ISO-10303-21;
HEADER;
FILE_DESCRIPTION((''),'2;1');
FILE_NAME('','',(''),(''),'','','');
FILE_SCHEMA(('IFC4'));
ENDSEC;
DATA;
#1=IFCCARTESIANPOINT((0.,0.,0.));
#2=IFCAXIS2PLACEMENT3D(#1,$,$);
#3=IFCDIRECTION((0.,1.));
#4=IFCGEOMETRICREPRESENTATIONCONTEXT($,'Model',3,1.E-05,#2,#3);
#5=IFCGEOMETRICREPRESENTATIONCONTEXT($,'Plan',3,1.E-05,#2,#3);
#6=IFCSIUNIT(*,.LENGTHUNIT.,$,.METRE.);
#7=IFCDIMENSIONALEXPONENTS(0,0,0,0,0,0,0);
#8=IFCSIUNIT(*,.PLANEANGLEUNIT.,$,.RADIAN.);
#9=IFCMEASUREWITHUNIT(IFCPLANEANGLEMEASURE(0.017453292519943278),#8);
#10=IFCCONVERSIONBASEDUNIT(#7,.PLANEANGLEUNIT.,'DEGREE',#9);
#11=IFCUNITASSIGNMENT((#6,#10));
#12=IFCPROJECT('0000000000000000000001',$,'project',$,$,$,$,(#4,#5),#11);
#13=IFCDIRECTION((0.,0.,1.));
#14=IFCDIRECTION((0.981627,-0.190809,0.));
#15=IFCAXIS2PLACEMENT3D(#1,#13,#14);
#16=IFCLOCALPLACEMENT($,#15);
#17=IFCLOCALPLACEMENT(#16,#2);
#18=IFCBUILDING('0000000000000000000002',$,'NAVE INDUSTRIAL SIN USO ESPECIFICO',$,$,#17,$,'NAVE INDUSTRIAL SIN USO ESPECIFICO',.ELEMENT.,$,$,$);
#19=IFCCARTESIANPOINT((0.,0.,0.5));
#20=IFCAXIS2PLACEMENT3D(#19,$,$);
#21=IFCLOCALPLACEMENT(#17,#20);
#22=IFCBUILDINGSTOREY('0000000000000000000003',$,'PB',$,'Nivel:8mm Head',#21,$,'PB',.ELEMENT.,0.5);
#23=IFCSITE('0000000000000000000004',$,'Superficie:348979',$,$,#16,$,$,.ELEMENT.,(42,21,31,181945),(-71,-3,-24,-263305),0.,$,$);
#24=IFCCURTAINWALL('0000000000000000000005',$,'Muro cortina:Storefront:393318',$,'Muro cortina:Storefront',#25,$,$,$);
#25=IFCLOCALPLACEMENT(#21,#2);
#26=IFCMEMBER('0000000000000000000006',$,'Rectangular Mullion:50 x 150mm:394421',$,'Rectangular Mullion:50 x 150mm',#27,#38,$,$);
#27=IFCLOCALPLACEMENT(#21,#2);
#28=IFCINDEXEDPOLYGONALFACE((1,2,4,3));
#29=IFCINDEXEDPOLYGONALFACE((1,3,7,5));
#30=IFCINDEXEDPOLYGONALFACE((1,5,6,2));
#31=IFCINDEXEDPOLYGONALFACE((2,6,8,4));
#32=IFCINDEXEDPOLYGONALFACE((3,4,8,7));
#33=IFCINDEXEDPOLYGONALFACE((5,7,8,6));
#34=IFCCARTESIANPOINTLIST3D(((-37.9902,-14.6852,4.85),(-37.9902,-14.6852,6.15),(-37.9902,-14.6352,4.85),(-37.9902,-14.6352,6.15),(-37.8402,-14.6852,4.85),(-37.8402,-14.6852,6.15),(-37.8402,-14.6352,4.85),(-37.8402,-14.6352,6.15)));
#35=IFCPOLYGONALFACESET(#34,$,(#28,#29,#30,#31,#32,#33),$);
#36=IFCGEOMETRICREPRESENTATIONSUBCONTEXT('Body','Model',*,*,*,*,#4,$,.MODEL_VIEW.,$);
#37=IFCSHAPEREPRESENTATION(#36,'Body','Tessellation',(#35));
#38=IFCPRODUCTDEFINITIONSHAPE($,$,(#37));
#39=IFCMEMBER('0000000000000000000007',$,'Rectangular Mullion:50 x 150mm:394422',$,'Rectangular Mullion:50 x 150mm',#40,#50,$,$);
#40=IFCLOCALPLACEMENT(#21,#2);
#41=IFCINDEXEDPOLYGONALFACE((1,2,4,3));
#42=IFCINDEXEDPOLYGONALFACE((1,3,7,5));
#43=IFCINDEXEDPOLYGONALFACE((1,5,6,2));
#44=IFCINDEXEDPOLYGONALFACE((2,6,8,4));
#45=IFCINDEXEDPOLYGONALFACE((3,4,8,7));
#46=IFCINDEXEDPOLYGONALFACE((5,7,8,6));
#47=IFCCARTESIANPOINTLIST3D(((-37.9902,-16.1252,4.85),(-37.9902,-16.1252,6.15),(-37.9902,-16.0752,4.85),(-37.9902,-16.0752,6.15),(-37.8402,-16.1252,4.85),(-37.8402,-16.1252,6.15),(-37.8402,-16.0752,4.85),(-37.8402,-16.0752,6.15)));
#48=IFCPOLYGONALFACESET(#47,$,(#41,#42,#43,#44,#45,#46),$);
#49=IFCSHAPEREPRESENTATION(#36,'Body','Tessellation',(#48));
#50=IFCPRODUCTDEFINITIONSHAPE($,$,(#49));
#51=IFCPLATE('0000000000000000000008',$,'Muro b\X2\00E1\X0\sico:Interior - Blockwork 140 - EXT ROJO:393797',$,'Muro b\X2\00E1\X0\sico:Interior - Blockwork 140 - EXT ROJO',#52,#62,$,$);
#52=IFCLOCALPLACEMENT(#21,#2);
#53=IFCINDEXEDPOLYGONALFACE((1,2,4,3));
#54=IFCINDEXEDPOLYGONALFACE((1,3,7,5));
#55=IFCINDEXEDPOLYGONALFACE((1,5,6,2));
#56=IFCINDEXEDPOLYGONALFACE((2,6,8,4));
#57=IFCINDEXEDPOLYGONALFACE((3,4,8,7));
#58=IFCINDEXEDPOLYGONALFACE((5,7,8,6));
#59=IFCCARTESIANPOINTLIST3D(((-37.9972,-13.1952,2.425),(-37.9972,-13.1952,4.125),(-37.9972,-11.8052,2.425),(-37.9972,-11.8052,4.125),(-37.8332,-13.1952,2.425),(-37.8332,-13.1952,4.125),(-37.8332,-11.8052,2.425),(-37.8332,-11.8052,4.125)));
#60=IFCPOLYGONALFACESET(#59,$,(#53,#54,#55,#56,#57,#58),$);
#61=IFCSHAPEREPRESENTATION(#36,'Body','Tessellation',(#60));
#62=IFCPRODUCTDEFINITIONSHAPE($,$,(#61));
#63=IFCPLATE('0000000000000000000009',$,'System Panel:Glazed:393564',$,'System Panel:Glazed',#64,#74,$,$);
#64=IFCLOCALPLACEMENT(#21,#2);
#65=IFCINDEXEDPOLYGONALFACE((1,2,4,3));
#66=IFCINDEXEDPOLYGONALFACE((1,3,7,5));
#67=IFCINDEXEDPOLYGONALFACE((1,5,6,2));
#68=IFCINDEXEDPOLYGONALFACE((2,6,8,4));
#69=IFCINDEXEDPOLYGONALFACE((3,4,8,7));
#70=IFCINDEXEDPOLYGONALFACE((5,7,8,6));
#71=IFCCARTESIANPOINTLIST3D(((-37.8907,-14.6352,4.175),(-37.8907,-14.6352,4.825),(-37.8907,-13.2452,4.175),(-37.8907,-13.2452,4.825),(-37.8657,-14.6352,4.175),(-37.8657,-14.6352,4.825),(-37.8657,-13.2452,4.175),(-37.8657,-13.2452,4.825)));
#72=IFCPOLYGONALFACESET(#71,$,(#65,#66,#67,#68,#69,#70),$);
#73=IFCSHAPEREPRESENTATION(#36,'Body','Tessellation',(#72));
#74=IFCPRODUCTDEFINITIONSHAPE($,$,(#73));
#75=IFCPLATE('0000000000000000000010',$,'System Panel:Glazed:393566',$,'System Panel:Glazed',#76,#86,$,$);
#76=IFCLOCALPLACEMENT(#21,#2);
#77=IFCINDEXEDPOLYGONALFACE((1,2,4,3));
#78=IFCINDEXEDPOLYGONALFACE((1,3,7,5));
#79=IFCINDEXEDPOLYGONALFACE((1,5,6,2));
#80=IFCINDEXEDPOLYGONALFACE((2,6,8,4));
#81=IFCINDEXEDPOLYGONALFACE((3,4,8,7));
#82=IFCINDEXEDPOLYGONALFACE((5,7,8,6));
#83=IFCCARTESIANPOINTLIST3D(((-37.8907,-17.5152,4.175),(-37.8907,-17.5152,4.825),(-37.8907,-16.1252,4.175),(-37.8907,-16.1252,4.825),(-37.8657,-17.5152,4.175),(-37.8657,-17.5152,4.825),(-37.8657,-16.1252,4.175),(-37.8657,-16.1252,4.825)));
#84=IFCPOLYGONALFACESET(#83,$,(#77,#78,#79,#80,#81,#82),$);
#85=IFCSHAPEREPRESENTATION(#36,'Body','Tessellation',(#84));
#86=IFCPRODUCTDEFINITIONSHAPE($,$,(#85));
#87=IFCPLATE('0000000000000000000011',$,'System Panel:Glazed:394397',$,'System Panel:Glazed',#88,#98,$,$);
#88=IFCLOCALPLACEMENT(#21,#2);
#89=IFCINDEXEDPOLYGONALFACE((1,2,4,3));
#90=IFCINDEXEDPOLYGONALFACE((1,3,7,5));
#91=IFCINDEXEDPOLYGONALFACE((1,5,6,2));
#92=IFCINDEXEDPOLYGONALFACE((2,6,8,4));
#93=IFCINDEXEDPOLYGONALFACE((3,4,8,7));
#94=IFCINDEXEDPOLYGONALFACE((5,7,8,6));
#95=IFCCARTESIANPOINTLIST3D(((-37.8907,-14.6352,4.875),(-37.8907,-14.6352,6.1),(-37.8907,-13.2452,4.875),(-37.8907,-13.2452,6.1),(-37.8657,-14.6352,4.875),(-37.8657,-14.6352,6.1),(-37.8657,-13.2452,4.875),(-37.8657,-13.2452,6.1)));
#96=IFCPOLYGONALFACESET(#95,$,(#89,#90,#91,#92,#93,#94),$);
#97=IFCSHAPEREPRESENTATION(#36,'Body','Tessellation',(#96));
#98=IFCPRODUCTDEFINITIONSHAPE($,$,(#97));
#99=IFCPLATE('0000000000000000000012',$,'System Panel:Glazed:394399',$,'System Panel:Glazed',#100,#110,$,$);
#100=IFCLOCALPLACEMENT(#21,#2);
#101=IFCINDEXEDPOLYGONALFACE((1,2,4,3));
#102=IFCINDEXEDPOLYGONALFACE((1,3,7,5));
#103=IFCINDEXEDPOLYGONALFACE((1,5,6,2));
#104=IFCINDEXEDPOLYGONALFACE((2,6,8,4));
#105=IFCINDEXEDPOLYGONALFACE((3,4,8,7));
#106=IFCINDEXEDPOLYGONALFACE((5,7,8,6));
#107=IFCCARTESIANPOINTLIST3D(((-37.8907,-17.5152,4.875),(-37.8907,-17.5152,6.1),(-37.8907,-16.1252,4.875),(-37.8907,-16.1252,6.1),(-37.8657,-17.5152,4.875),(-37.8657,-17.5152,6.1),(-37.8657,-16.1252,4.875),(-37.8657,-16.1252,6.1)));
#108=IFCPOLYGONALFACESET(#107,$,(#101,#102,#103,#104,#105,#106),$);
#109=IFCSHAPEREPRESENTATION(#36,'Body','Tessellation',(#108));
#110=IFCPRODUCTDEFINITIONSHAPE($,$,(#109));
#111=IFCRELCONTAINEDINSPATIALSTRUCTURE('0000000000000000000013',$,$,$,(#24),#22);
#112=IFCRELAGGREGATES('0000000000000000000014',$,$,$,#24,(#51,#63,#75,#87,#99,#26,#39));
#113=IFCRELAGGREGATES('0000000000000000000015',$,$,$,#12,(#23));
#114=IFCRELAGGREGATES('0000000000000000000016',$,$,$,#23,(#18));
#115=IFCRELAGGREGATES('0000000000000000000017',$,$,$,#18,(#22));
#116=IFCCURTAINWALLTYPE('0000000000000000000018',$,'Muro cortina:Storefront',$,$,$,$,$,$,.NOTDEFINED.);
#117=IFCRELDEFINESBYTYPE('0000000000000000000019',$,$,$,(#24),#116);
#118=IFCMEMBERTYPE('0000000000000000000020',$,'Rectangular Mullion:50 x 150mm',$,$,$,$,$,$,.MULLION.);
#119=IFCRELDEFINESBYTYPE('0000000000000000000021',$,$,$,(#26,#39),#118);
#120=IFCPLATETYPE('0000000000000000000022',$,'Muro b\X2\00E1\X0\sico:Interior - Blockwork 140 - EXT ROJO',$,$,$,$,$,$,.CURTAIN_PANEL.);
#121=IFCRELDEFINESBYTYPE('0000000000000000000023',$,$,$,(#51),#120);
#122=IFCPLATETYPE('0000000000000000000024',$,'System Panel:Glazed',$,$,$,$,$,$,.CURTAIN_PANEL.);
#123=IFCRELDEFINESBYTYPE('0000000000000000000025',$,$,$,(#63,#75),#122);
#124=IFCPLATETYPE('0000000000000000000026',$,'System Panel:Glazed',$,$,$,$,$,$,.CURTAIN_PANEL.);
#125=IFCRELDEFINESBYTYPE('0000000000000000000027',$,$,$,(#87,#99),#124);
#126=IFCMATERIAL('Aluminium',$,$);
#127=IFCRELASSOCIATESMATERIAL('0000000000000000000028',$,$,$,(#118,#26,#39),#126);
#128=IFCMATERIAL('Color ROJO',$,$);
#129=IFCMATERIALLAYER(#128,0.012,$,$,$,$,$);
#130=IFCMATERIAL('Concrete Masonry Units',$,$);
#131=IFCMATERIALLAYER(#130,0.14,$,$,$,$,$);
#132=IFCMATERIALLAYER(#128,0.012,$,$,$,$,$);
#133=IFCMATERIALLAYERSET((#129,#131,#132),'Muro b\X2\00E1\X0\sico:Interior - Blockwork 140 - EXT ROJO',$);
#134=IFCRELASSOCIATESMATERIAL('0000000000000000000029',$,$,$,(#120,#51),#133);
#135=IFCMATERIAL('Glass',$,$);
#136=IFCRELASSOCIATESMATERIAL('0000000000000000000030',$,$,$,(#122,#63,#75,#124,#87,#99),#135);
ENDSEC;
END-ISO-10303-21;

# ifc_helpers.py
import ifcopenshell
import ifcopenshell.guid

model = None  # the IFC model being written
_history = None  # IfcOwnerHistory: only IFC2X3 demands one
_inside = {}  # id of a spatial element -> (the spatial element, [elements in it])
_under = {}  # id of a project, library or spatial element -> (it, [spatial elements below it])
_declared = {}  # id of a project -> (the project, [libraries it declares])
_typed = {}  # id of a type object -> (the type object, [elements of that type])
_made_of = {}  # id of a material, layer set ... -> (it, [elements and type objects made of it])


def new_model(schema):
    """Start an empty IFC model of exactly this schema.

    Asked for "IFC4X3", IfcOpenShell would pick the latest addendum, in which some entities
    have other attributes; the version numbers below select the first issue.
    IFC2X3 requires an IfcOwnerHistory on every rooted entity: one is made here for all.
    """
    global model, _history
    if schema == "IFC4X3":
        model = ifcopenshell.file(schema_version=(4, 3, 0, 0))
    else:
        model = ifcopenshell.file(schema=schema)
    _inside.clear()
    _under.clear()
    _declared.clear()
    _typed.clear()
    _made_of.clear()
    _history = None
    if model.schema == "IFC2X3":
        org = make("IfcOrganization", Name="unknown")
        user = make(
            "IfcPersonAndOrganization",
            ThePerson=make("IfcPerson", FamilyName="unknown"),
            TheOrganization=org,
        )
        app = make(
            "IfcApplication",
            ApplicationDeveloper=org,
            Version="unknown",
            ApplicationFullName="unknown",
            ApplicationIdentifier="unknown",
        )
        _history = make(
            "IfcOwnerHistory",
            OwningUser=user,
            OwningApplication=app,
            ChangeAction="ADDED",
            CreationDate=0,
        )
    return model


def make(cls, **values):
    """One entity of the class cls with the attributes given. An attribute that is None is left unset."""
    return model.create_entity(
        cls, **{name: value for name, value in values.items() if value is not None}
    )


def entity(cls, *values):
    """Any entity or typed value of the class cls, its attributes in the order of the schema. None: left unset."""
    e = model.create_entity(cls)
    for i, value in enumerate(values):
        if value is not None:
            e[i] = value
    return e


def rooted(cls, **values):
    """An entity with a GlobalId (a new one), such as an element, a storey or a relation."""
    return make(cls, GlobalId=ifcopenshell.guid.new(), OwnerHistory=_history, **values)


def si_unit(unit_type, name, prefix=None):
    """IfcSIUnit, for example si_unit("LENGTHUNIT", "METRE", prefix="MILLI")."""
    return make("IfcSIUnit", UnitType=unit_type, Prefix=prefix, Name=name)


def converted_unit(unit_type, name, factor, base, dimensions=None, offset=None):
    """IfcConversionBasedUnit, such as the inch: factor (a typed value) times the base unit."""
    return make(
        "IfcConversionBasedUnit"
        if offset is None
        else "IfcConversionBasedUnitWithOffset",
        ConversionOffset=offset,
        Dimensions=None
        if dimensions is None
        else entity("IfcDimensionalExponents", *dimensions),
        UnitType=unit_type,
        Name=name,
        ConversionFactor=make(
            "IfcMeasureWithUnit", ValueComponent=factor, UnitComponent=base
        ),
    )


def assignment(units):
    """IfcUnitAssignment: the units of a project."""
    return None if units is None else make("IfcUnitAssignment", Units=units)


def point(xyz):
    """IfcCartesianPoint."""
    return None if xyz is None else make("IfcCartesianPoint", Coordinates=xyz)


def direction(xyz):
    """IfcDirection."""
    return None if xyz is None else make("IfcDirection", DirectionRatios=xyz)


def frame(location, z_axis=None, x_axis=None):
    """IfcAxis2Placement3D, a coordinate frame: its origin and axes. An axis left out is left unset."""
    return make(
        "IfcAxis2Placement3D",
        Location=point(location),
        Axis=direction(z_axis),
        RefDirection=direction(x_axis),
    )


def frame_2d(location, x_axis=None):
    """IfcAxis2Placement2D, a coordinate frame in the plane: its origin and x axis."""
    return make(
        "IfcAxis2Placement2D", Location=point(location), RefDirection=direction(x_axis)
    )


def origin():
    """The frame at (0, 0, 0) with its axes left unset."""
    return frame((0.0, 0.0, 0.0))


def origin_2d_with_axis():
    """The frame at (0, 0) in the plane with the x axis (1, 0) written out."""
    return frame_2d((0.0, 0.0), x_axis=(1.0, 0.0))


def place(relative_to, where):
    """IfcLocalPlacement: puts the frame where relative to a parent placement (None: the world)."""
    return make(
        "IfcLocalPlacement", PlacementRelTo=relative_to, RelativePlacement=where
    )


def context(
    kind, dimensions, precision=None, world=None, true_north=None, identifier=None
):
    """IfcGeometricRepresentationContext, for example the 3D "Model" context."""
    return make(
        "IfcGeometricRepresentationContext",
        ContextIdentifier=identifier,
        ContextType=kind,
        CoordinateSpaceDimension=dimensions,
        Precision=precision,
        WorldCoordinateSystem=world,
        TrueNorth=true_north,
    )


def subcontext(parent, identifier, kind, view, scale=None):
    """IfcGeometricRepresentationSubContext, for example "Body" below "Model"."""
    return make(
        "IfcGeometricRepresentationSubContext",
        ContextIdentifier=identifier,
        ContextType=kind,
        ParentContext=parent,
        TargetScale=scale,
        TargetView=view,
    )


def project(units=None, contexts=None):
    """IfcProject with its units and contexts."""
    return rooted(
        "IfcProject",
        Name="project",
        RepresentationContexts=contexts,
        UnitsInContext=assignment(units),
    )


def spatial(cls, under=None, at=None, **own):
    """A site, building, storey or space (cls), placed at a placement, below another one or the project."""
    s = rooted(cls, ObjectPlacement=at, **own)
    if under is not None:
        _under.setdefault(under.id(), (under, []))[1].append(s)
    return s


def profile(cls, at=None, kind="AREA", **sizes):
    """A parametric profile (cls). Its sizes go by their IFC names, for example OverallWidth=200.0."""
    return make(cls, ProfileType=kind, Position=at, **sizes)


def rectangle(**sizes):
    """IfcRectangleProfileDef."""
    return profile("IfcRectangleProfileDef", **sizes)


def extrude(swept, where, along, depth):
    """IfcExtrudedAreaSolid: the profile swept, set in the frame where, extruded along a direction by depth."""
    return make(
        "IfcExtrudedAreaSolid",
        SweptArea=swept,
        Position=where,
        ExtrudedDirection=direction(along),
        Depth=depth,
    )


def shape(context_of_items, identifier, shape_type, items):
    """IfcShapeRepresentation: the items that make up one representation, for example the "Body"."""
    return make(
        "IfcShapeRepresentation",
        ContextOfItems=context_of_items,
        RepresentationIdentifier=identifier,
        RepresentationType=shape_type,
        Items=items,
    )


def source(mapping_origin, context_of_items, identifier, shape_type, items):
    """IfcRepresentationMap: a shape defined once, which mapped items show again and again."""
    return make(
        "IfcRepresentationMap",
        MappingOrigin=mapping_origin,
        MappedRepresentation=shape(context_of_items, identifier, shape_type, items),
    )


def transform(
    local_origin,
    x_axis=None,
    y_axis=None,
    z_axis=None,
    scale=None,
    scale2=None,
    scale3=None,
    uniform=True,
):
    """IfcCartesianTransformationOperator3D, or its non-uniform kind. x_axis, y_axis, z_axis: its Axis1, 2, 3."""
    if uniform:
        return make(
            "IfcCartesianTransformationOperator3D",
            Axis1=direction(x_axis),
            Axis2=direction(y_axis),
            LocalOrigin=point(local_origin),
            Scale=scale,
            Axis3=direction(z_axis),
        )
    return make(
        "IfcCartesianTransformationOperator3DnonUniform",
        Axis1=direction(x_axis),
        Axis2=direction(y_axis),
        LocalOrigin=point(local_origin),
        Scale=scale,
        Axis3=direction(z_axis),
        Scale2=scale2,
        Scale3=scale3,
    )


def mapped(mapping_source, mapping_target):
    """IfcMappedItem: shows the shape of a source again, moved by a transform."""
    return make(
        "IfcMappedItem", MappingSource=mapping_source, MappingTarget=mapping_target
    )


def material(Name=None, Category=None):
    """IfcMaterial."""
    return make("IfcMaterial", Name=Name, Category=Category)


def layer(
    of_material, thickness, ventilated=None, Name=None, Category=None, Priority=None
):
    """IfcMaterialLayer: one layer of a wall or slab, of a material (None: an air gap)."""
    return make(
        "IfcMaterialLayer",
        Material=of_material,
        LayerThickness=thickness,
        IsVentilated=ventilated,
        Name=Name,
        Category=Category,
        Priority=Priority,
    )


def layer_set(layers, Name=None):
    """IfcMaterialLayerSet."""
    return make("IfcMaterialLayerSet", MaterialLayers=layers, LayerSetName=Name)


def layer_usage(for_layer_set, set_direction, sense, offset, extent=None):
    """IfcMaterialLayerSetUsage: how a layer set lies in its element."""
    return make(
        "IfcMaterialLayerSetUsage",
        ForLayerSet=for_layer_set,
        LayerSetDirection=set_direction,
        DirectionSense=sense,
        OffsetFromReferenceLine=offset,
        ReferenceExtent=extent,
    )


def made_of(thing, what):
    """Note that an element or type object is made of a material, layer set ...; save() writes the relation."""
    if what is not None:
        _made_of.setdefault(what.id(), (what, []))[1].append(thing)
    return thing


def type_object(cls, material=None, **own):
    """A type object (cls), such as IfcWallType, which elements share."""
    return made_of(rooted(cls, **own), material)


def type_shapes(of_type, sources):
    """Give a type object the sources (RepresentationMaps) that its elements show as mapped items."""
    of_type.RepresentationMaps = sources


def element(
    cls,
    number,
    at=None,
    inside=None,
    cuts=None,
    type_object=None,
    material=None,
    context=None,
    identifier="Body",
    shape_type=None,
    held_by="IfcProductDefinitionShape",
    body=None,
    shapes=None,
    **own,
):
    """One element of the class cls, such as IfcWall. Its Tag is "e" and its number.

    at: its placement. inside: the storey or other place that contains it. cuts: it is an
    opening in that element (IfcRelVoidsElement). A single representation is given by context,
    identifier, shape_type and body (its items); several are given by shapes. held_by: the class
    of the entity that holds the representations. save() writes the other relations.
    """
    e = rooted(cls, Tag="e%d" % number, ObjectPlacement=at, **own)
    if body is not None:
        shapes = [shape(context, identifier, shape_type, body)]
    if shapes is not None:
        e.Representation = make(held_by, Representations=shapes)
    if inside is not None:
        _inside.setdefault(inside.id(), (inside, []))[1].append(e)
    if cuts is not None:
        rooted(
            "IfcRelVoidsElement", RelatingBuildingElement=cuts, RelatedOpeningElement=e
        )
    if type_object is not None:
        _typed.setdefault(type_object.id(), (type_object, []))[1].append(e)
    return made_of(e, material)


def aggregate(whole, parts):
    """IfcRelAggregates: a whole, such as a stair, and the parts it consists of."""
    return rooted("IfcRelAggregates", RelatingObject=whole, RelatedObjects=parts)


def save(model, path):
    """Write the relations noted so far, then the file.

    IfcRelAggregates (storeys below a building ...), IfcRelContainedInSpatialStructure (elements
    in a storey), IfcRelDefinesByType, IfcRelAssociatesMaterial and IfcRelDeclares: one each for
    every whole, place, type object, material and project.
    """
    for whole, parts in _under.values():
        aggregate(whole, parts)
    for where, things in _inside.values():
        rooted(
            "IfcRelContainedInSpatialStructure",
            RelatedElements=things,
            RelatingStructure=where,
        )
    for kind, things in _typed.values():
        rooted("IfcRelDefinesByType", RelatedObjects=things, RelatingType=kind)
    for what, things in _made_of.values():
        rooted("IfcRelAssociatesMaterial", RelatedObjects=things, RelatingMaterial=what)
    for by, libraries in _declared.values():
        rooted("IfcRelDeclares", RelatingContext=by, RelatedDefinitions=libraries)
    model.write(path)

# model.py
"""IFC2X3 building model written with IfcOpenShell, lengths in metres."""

from ifc_helpers import new_model, entity, si_unit, converted_unit, direction, frame, frame_2d, origin, origin_2d_with_axis, place, context, subcontext, project, spatial, rectangle, extrude, source, transform, mapped, material, layer, layer_set, layer_usage, type_object, type_shapes, element, aggregate, save


model = new_model("IFC2X3")

# Units and contexts
model_context = context("Model", 3, precision=1e-05, world=origin(), true_north=direction((0.0, 1.0)))
plan_context = context("Plan", 3, precision=1e-05, world=origin(), true_north=direction((0.0, 1.0)))
body_context = subcontext(model_context, "Body", "Model", "MODEL_VIEW")
ifc_project = project(units=[si_unit("LENGTHUNIT", "METRE"), converted_unit("PLANEANGLEUNIT", "DEGREE", entity("IfcPlaneAngleMeasure", 0.017453292519943278), si_unit("PLANEANGLEUNIT", "RADIAN"), dimensions=[0, 0, 0, 0, 0, 0, 0])], contexts=[model_context, plan_context])

# Site, building, storey
site_placement = place(None, frame((0.0, 0.0, 0.0), z_axis=(0.0, 0.0, 1.0), x_axis=(0.981627, -0.190809, 0.0)))
site = spatial("IfcSite", under=ifc_project, at=site_placement, Name="Superficie:348979", CompositionType="ELEMENT", RefLatitude=(42, 21, 31, 181945), RefLongitude=(-71, -3, -24, -263305), RefElevation=0.0)
building_placement = place(site_placement, origin())
building = spatial("IfcBuilding", under=site, at=building_placement, Name="NAVE INDUSTRIAL SIN USO ESPECIFICO", LongName="NAVE INDUSTRIAL SIN USO ESPECIFICO", CompositionType="ELEMENT")
storey_placement = place(building_placement, frame((0.0, 0.0, 0.5)))
storey = spatial("IfcBuildingStorey", under=building, at=storey_placement, Name="PB", ObjectType="Nivel:8mm Head", LongName="PB", CompositionType="ELEMENT", Elevation=0.5)

# Curtain wall, members, plates
curtain_wall_type = type_object("IfcCurtainWallType", Name="Muro cortina:Storefront", PredefinedType="NOTDEFINED")
curtain_wall_placement = place(storey_placement, frame((0.0, 0.0, -0.5)))
curtain_wall = element("IfcCurtainWall", 1, at=curtain_wall_placement, inside=storey, type_object=curtain_wall_type, Name="Muro cortina:Storefront:393318", ObjectType="Muro cortina:Storefront")
ifc_material_1 = material(Name="Aluminium")
member_type_1 = type_object("IfcMemberType", Name="Rectangular Mullion:50 x 150mm", PredefinedType="MULLION", material=ifc_material_1)
shared_shape_1 = source(origin(), body_context, "Body", "SweptSolid", [
    extrude(rectangle(XDim=0.05, YDim=0.15, at=origin_2d_with_axis()), frame((0.0, 0.0, -1.3), z_axis=(0.0, 0.0, 1.0), x_axis=(-1.0, 0.0, 0.0)), (0.0, 0.0, 1.0), 1.3),
])
type_shapes(member_type_1, [shared_shape_1])
member_1_placement = place(curtain_wall_placement, frame((-37.9152, -14.6602, 5.35), z_axis=(0.0, 0.0, -1.0), x_axis=(0.0, -1.0, 0.0)))
member_1 = element("IfcMember", 2, at=member_1_placement, type_object=member_type_1, material=ifc_material_1, Name="Rectangular Mullion:50 x 150mm:394421", ObjectType="Rectangular Mullion:50 x 150mm", context=body_context, shape_type="MappedRepresentation", body=[
    mapped(shared_shape_1, transform((0.0, 0.0, 0.0), scale=1.0)),
])
member_2_placement = place(curtain_wall_placement, frame((-37.9152, -16.1002, 5.35), z_axis=(0.0, 0.0, -1.0), x_axis=(0.0, -1.0, 0.0)))
member_2 = element("IfcMember", 3, at=member_2_placement, type_object=member_type_1, material=ifc_material_1, Name="Rectangular Mullion:50 x 150mm:394422", ObjectType="Rectangular Mullion:50 x 150mm", context=body_context, shape_type="MappedRepresentation", body=[
    mapped(shared_shape_1, transform((0.0, 0.0, 0.0), scale=1.0)),
])
ifc_material_2 = material(Name="Color ROJO")
ifc_layer_1 = layer(ifc_material_2, 0.012)
ifc_material_3 = material(Name="Concrete Masonry Units")
ifc_layer_2 = layer(ifc_material_3, 0.14)
ifc_layer_3 = layer(ifc_material_2, 0.012)
ifc_layer_set = layer_set([ifc_layer_1, ifc_layer_2, ifc_layer_3], Name="Muro básico:Interior - Blockwork 140 - EXT ROJO")
ifc_layer_usage = layer_usage(ifc_layer_set, "AXIS2", "NEGATIVE", 0.082)
plate_type_1 = type_object("IfcPlateType", Name="Muro básico:Interior - Blockwork 140 - EXT ROJO", PredefinedType="CURTAIN_PANEL", material=ifc_layer_set)
plate_1_placement = place(storey_placement, frame((-37.9152, -11.8052, 2.425), z_axis=(0.0, 0.0, 1.0), x_axis=(0.0, -1.0, 0.0)))
plate_1 = element("IfcPlate", 4, at=plate_1_placement, type_object=plate_type_1, material=ifc_layer_usage, Name="Muro básico:Interior - Blockwork 140 - EXT ROJO:393797", ObjectType="Muro básico:Interior - Blockwork 140 - EXT ROJO", context=body_context, shape_type="SweptSolid", body=[
    extrude(rectangle(XDim=0.164, YDim=1.39, at=frame_2d((0.0, 0.0), x_axis=(1.0, 0.0))), frame((0.695, 0.0, 0.0), z_axis=(0.0, 0.0, 1.0), x_axis=(0.0, 1.0, 0.0)), (0.0, 0.0, 1.0), 1.7),
])
ifc_material_4 = material(Name="Glass")
plate_type_2 = type_object("IfcPlateType", Name="System Panel:Glazed", PredefinedType="CURTAIN_PANEL", material=ifc_material_4)
shared_shape_2 = source(origin(), body_context, "Body", "SweptSolid", [
    extrude(rectangle(XDim=0.025, YDim=1.39, at=origin_2d_with_axis()), frame((0.695, 0.0125, 0.0), z_axis=(0.0, 0.0, 1.0), x_axis=(0.0, 1.0, 0.0)), (0.0, 0.0, 1.0), 0.65),
])
type_shapes(plate_type_2, [shared_shape_2])
plate_2_placement = place(curtain_wall_placement, frame((-37.8907, -13.2452, 4.675), z_axis=(0.0, 0.0, 1.0), x_axis=(0.0, -1.0, 0.0)))
plate_2 = element("IfcPlate", 5, at=plate_2_placement, type_object=plate_type_2, material=ifc_material_4, Name="System Panel:Glazed:393564", ObjectType="System Panel:Glazed", context=body_context, shape_type="MappedRepresentation", body=[
    mapped(shared_shape_2, transform((0.0, 0.0, 0.0), scale=1.0)),
])
plate_3_placement = place(curtain_wall_placement, frame((-37.8907, -16.1252, 4.675), z_axis=(0.0, 0.0, 1.0), x_axis=(0.0, -1.0, 0.0)))
plate_3 = element("IfcPlate", 6, at=plate_3_placement, type_object=plate_type_2, material=ifc_material_4, Name="System Panel:Glazed:393566", ObjectType="System Panel:Glazed", context=body_context, shape_type="MappedRepresentation", body=[
    mapped(shared_shape_2, transform((0.0, 0.0, 0.0), scale=1.0)),
])
plate_type_3 = type_object("IfcPlateType", Name="System Panel:Glazed", PredefinedType="CURTAIN_PANEL", material=ifc_material_4)
shared_shape_3 = source(origin(), body_context, "Body", "SweptSolid", [
    extrude(rectangle(XDim=0.025, YDim=1.39, at=origin_2d_with_axis()), frame((0.695, 0.0125, 0.0), z_axis=(0.0, 0.0, 1.0), x_axis=(0.0, 1.0, 0.0)), (0.0, 0.0, 1.0), 1.225),
])
type_shapes(plate_type_3, [shared_shape_3])
plate_4_placement = place(curtain_wall_placement, frame((-37.8907, -13.2452, 5.375), z_axis=(0.0, 0.0, 1.0), x_axis=(0.0, -1.0, 0.0)))
plate_4 = element("IfcPlate", 7, at=plate_4_placement, type_object=plate_type_3, material=ifc_material_4, Name="System Panel:Glazed:394397", ObjectType="System Panel:Glazed", context=body_context, shape_type="MappedRepresentation", body=[
    mapped(shared_shape_3, transform((0.0, 0.0, 0.0), scale=1.0)),
])
plate_5_placement = place(curtain_wall_placement, frame((-37.8907, -16.1252, 5.375), z_axis=(0.0, 0.0, 1.0), x_axis=(0.0, -1.0, 0.0)))
plate_5 = element("IfcPlate", 8, at=plate_5_placement, type_object=plate_type_3, material=ifc_material_4, Name="System Panel:Glazed:394399", ObjectType="System Panel:Glazed", context=body_context, shape_type="MappedRepresentation", body=[
    mapped(shared_shape_3, transform((0.0, 0.0, 0.0), scale=1.0)),
])
aggregate(curtain_wall, [plate_1, plate_2, plate_3, plate_4, plate_5, member_1, member_2])

save(model, "model.ifc")
